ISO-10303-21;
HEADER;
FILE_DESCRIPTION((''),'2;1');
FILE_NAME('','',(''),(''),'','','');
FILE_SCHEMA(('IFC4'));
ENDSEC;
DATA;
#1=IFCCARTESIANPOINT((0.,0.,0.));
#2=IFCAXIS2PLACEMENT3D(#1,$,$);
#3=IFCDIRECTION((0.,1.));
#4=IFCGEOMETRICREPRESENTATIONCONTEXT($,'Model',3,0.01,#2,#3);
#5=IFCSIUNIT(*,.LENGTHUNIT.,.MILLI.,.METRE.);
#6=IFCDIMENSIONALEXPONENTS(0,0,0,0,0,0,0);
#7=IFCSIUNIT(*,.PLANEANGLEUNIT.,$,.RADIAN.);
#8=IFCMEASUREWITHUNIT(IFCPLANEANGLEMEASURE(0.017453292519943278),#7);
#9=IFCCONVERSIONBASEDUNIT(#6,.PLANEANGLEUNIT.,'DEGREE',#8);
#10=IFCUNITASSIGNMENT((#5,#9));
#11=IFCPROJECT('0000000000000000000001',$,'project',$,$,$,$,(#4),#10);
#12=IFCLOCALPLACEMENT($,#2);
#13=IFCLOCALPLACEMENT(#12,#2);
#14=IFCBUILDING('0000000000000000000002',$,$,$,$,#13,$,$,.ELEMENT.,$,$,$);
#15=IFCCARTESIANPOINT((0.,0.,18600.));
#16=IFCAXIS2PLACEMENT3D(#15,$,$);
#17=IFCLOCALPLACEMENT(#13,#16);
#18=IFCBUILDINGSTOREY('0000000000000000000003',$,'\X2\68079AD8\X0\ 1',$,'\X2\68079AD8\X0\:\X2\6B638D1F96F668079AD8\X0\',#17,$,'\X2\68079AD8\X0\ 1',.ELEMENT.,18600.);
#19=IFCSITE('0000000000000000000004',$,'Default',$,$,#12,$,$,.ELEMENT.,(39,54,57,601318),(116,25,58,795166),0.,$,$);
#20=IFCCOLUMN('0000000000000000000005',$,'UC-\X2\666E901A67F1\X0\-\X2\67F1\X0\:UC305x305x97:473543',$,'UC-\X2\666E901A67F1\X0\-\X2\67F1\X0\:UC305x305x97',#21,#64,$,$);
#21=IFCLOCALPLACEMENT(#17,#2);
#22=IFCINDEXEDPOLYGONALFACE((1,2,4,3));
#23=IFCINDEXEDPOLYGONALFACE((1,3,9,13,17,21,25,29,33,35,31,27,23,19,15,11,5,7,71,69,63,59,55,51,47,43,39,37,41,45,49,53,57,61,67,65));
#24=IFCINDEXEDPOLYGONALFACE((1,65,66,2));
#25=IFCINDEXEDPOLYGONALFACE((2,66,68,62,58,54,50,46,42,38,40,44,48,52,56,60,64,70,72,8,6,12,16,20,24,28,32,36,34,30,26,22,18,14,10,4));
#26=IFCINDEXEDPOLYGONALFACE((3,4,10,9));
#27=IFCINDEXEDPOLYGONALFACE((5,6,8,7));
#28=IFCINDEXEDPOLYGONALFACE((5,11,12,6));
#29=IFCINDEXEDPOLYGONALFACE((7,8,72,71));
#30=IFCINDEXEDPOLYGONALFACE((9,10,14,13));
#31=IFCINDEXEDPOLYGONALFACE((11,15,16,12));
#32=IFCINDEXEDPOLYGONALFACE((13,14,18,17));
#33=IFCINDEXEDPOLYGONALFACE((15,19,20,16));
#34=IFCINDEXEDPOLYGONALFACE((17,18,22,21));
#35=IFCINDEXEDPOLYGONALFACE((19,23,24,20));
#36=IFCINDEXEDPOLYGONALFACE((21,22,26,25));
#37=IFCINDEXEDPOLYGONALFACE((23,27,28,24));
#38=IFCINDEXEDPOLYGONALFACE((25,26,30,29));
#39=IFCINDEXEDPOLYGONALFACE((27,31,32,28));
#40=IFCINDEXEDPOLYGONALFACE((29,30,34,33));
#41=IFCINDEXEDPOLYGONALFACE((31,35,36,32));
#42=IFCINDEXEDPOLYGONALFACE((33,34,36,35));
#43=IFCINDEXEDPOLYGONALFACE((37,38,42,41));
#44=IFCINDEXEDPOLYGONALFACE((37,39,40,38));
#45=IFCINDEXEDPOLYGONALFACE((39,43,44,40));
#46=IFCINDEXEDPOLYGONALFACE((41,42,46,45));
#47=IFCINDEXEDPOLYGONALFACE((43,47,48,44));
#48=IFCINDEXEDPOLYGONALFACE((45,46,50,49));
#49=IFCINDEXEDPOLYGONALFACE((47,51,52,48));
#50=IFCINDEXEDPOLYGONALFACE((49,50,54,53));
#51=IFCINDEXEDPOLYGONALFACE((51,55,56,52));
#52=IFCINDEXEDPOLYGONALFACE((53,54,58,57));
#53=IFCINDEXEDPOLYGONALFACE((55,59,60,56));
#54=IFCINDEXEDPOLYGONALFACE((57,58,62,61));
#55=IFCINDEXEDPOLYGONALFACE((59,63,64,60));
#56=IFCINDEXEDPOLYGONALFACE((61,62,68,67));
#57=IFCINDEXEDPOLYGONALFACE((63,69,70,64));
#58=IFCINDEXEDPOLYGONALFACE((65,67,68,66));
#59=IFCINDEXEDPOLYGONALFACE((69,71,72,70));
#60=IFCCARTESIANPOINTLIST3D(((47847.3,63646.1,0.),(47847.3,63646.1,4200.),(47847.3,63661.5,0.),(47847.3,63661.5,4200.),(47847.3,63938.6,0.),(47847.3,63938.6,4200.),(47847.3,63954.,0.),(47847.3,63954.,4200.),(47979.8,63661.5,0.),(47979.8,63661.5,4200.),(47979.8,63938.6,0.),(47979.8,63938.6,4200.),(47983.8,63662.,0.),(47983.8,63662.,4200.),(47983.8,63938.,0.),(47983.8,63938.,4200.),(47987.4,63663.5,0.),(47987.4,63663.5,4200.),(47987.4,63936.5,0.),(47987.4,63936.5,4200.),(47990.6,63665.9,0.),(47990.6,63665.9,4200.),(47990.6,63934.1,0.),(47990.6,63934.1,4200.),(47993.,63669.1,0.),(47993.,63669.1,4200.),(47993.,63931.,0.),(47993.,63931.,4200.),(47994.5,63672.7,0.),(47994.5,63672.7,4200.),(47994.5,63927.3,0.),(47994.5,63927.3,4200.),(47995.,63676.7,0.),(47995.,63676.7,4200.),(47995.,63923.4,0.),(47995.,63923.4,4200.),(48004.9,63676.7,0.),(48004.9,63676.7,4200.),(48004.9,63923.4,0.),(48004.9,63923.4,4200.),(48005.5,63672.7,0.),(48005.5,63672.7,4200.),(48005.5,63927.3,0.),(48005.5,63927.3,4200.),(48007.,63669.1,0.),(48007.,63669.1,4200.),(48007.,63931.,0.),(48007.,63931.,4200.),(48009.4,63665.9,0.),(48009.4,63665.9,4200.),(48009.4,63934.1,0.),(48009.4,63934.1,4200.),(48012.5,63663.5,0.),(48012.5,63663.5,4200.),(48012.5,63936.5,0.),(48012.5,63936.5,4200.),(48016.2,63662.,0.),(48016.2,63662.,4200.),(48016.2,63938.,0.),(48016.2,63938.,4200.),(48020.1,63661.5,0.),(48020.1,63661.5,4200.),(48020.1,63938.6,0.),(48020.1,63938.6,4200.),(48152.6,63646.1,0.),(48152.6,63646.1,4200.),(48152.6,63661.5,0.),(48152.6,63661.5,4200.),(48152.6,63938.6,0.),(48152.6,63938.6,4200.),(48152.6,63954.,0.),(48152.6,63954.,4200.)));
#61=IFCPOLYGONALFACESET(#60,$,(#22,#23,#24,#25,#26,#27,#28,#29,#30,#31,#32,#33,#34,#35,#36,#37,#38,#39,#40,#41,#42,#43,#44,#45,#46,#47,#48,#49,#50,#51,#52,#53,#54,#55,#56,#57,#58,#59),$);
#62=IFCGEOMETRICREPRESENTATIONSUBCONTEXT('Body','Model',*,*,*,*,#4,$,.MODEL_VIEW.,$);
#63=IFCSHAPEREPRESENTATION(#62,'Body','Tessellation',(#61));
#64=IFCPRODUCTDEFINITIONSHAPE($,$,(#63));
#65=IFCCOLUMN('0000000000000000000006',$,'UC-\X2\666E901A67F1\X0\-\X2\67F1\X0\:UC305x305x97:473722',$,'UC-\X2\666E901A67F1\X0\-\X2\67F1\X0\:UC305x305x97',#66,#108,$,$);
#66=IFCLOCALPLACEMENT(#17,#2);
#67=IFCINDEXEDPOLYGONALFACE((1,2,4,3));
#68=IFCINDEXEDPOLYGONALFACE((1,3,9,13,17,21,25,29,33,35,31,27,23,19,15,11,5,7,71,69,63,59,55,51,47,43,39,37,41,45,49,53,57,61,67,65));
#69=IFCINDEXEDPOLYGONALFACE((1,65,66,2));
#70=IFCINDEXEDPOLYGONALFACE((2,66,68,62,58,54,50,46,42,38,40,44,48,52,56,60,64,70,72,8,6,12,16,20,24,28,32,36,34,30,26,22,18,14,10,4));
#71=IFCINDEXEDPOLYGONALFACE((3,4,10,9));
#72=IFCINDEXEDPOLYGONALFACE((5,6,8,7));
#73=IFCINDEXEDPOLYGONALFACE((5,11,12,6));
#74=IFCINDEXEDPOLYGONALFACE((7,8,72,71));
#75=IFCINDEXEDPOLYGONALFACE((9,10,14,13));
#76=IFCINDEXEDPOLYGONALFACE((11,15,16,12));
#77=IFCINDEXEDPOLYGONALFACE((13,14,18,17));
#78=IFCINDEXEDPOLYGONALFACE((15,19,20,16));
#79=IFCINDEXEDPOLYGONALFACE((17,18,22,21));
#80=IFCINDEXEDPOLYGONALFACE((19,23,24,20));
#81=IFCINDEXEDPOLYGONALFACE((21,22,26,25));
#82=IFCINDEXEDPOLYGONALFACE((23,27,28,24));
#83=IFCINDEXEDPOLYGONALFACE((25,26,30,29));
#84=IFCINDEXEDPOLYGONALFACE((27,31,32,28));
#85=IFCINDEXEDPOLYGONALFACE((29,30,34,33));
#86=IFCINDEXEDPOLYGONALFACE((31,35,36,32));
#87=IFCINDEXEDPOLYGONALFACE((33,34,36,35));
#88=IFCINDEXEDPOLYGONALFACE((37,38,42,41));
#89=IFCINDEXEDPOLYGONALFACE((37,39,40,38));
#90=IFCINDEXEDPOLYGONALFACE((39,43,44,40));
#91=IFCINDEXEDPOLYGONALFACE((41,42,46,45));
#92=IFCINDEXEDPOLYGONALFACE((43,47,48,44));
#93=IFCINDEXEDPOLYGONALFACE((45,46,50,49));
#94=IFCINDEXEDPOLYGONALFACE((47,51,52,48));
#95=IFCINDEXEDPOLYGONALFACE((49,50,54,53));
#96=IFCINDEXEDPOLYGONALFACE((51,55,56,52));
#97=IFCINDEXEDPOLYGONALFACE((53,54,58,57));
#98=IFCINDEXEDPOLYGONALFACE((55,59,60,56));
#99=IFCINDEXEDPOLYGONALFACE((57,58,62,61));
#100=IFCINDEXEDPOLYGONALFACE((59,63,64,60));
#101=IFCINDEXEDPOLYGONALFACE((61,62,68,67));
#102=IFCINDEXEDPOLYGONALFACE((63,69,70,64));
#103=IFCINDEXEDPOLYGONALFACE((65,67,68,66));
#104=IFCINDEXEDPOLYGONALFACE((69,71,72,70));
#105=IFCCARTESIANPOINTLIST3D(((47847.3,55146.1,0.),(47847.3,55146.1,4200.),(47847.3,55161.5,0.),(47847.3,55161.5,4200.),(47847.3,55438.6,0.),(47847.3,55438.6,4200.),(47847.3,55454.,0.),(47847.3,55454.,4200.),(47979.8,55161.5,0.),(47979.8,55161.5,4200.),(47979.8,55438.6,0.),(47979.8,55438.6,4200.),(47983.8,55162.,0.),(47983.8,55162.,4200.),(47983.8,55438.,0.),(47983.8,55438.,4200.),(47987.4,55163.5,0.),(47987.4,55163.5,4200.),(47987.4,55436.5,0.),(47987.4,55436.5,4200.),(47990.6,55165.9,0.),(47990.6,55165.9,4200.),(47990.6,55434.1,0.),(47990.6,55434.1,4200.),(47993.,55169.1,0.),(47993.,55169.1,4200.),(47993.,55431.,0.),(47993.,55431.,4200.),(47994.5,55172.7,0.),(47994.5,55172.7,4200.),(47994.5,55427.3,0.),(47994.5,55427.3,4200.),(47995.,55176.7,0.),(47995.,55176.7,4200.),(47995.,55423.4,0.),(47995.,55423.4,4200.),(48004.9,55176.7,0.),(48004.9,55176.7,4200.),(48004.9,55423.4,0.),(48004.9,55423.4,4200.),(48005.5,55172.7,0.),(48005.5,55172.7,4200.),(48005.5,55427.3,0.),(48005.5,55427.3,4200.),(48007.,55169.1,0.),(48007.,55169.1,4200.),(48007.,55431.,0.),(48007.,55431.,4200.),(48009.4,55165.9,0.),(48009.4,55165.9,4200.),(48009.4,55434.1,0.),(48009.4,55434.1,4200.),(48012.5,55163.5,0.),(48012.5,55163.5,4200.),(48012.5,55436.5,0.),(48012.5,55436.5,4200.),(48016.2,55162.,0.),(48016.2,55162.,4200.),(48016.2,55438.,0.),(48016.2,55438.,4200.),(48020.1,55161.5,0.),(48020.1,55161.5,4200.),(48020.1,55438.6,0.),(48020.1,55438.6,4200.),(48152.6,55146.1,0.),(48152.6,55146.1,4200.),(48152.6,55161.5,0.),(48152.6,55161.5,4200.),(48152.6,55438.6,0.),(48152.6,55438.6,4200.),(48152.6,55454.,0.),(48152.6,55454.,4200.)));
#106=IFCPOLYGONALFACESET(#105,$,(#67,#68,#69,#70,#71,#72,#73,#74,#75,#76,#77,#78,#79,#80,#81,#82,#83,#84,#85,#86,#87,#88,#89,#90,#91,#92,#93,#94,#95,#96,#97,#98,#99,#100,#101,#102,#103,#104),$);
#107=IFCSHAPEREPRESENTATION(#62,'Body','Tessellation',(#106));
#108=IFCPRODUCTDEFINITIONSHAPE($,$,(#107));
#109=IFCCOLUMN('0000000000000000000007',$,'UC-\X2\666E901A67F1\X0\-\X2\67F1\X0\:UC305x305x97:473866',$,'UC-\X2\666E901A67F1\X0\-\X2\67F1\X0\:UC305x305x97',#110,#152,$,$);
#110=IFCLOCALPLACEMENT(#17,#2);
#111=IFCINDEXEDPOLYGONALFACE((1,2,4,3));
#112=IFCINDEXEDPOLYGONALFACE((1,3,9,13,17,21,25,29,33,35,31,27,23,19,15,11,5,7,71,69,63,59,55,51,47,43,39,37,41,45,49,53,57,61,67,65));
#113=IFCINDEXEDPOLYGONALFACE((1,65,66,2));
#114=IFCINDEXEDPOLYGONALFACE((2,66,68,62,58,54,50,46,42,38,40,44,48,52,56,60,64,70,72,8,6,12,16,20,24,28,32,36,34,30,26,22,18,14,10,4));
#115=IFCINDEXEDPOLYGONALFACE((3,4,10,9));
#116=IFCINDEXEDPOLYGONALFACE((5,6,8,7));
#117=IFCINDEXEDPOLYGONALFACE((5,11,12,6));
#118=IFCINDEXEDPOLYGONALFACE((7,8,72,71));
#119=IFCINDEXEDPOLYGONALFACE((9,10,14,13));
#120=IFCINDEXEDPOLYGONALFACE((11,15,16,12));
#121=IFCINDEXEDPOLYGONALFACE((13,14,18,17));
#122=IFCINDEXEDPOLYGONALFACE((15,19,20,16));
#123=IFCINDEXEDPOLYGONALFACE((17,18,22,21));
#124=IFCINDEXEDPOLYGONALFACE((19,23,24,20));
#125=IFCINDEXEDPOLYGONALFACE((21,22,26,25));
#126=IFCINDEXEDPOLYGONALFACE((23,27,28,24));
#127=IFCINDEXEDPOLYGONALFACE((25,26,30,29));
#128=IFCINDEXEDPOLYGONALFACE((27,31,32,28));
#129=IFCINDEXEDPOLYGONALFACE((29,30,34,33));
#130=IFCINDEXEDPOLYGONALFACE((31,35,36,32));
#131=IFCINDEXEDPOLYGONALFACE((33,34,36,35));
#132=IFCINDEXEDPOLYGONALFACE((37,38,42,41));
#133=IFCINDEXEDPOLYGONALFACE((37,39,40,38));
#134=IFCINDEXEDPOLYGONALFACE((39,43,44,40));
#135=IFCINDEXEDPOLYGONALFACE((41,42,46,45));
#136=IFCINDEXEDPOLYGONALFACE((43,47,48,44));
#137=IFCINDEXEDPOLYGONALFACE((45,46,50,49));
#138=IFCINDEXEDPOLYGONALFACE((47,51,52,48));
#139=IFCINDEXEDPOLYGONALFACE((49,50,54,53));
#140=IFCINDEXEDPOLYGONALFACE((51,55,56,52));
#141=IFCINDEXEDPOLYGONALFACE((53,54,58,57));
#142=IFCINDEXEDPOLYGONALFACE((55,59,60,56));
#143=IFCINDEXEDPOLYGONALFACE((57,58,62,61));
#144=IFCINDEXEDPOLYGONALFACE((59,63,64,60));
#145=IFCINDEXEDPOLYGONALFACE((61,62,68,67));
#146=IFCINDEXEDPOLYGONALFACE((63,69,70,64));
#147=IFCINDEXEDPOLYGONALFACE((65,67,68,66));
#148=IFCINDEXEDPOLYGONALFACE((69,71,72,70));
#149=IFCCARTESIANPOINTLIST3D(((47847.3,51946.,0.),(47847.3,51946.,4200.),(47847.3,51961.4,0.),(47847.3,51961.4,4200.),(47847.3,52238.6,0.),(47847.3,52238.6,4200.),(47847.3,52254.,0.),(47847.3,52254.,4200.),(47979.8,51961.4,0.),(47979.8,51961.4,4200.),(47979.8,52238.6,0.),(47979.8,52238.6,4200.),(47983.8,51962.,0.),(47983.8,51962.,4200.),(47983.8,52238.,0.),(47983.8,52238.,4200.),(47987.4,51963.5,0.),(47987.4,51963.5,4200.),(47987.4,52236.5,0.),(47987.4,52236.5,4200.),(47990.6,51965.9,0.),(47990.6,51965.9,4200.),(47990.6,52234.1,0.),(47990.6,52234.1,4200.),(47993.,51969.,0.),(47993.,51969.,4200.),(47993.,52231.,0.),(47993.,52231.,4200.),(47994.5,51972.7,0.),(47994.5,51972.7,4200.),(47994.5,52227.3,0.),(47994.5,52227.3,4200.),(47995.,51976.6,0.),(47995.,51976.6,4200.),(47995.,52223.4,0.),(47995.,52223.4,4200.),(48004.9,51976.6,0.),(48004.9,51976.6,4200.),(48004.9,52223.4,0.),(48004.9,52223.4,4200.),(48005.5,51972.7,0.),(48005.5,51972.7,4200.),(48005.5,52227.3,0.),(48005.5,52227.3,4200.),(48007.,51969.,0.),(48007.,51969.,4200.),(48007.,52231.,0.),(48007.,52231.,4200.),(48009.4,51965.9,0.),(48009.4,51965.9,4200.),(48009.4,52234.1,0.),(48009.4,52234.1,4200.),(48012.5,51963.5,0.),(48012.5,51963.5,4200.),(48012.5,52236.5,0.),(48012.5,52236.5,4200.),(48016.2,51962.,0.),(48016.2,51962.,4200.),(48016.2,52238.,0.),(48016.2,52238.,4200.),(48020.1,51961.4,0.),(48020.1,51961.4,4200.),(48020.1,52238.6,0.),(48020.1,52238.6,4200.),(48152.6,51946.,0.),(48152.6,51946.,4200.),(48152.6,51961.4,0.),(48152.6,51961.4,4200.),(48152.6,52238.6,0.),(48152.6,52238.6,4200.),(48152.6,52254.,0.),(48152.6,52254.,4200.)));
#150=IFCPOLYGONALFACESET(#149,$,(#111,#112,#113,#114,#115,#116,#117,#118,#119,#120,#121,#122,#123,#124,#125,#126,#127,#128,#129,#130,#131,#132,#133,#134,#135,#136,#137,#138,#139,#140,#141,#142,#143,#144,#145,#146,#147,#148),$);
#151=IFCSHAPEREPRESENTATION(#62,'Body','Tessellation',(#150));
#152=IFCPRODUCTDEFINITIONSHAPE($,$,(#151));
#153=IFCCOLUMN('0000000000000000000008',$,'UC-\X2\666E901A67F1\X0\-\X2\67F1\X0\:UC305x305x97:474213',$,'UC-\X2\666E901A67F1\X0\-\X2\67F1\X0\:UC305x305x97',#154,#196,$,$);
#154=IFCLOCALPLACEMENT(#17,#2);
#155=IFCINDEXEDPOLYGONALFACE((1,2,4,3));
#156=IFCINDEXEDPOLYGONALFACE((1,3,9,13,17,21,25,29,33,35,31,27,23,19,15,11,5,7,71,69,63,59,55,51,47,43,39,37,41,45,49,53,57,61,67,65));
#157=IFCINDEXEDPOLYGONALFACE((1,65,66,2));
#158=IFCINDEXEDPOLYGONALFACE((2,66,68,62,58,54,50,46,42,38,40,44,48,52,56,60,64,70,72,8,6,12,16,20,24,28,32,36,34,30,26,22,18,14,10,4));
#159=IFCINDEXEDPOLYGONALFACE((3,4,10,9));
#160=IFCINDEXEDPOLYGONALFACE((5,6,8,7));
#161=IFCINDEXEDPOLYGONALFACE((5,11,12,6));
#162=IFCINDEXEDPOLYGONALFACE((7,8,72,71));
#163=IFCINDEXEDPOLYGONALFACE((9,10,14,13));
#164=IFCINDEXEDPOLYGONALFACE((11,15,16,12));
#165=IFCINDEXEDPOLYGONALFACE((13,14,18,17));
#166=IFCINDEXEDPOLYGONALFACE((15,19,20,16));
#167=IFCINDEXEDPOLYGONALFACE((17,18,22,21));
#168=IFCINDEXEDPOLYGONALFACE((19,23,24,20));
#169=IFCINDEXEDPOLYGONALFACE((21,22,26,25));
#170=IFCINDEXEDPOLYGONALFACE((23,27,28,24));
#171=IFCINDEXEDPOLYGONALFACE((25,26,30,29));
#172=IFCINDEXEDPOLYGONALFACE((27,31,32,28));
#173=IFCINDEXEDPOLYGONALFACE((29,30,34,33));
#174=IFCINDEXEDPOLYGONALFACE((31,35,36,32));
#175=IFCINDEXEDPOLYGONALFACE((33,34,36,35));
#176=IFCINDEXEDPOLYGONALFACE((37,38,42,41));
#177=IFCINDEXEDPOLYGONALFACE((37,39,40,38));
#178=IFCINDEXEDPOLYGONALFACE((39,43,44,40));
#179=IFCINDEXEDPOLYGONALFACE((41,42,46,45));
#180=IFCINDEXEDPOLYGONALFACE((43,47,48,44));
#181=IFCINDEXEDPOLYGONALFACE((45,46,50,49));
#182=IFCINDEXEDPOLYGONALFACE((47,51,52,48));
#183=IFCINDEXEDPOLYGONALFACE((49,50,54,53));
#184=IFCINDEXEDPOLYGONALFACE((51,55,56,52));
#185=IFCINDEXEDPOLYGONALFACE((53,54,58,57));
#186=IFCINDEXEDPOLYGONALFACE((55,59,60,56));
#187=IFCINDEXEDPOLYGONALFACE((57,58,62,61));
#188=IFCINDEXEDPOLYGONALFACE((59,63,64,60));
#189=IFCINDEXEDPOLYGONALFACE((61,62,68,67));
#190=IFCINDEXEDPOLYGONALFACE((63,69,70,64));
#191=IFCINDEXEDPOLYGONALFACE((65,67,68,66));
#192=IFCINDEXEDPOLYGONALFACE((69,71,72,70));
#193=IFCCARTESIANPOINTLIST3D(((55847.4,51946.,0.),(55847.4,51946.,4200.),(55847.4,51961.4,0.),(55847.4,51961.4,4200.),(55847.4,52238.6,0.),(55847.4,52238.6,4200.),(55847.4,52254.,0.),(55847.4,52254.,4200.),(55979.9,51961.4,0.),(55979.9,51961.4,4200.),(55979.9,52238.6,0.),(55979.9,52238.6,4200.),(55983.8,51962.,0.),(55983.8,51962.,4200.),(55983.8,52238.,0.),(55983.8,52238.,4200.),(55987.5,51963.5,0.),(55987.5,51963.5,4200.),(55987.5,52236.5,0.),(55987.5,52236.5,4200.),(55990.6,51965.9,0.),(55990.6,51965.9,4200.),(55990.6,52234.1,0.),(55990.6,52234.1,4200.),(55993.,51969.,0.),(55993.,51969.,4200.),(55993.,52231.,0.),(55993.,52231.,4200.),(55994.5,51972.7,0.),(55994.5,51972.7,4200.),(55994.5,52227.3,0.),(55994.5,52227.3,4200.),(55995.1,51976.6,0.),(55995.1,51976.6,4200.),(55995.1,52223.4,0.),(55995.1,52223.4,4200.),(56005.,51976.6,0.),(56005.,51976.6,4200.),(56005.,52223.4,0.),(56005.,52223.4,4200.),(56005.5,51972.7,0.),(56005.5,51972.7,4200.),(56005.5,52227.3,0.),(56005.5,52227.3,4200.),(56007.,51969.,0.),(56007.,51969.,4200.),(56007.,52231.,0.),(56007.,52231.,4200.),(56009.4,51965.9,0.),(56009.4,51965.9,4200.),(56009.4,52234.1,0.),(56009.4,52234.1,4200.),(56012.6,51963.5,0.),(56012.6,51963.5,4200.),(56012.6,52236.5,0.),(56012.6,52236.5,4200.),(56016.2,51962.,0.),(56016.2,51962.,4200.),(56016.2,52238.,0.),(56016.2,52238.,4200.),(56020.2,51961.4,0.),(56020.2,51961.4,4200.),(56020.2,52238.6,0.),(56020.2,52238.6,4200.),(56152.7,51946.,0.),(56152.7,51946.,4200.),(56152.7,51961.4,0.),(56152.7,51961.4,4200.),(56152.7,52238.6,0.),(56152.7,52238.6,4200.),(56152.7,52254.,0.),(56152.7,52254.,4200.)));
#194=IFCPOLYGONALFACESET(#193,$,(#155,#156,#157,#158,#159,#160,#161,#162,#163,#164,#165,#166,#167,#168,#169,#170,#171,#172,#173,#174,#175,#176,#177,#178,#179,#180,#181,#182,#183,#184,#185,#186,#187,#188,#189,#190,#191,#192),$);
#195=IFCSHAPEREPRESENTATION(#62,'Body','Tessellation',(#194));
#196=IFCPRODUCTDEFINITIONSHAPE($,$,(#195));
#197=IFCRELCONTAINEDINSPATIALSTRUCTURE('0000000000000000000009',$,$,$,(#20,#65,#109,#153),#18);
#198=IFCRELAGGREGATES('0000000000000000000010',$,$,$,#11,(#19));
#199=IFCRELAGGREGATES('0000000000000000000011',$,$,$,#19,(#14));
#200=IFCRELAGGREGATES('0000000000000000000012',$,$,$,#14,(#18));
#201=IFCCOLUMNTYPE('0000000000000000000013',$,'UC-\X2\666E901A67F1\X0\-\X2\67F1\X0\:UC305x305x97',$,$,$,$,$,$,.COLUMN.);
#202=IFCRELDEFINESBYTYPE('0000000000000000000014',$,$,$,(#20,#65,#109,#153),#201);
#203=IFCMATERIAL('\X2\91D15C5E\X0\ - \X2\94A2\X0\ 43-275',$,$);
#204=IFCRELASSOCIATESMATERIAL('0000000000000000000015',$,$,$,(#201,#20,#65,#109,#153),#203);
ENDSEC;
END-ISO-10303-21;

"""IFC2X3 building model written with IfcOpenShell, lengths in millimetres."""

from ifc_helpers import new_model, entity, si_unit, converted_unit, direction, frame, origin, origin_2d_with_axis, place, context, subcontext, project, spatial, i_section, extrude, source, transform, mapped, material, type_object, type_shapes, element, save


model = new_model("IFC2X3")

# Units and contexts
model_context = context("Model", 3, precision=0.01, world=origin(), true_north=direction((0.0, 1.0)))
body_context = subcontext(model_context, "Body", "Model", "MODEL_VIEW")
ifc_project = project(units=[si_unit("LENGTHUNIT", "METRE", prefix="MILLI"), converted_unit("PLANEANGLEUNIT", "DEGREE", entity("IfcPlaneAngleMeasure", 0.017453292519943278), si_unit("PLANEANGLEUNIT", "RADIAN"), dimensions=[0, 0, 0, 0, 0, 0, 0])], contexts=[model_context])

# Site, building, storey
site_placement = place(None, origin())
site = spatial("IfcSite", under=ifc_project, at=site_placement, Name="Default", CompositionType="ELEMENT", RefLatitude=(39, 54, 57, 601318), RefLongitude=(116, 25, 58, 795166), RefElevation=0.0)
building_placement = place(site_placement, origin())
building = spatial("IfcBuilding", under=site, at=building_placement, CompositionType="ELEMENT")
storey_placement = place(building_placement, frame((0.0, 0.0, 18600.0)))
storey = spatial("IfcBuildingStorey", under=building, at=storey_placement, Name="标高 1", ObjectType="标高:正负零标高", LongName="标高 1", CompositionType="ELEMENT", Elevation=18600.0)

# Columns
ifc_material_1 = material(Name="金属 - 钢 43-275")
column_type = type_object("IfcColumnType", Name="UC-普通柱-柱:UC305x305x97", PredefinedType="COLUMN", material=ifc_material_1)
shared_shape_1 = source(origin(), body_context, "Body", "SweptSolid", [
    extrude(i_section(OverallWidth=305.3, OverallDepth=307.9, WebThickness=9.9, FlangeThickness=15.4, FilletRadius=15.2, at=origin_2d_with_axis()), frame((0.0, 0.0, 18600.0), z_axis=(0.0, 0.0, 1.0), x_axis=(-1.0, 0.0, 0.0)), (0.0, 0.0, 1.0), 4200.0),
])
type_shapes(column_type, [shared_shape_1])
for number, where, name in (
    (1, (48000.0, 63800.0, -18600.0), "UC-普通柱-柱:UC305x305x97:473543"),
    (2, (48000.0, 55300.0, -18600.0), "UC-普通柱-柱:UC305x305x97:473722"),
    (3, (48000.0, 52100.0, -18600.0), "UC-普通柱-柱:UC305x305x97:473866"),
    (4, (56000.0, 52100.0, -18600.0), "UC-普通柱-柱:UC305x305x97:474213"),
):
    element("IfcColumn", number, at=place(storey_placement, frame(where)), inside=storey, type_object=column_type, material=ifc_material_1, Name=name, ObjectType="UC-普通柱-柱:UC305x305x97", context=body_context, shape_type="MappedRepresentation", body=[
        mapped(shared_shape_1, transform((0.0, 0.0, 0.0), scale=1.0)),
    ])

save(model, "model.ifc")
